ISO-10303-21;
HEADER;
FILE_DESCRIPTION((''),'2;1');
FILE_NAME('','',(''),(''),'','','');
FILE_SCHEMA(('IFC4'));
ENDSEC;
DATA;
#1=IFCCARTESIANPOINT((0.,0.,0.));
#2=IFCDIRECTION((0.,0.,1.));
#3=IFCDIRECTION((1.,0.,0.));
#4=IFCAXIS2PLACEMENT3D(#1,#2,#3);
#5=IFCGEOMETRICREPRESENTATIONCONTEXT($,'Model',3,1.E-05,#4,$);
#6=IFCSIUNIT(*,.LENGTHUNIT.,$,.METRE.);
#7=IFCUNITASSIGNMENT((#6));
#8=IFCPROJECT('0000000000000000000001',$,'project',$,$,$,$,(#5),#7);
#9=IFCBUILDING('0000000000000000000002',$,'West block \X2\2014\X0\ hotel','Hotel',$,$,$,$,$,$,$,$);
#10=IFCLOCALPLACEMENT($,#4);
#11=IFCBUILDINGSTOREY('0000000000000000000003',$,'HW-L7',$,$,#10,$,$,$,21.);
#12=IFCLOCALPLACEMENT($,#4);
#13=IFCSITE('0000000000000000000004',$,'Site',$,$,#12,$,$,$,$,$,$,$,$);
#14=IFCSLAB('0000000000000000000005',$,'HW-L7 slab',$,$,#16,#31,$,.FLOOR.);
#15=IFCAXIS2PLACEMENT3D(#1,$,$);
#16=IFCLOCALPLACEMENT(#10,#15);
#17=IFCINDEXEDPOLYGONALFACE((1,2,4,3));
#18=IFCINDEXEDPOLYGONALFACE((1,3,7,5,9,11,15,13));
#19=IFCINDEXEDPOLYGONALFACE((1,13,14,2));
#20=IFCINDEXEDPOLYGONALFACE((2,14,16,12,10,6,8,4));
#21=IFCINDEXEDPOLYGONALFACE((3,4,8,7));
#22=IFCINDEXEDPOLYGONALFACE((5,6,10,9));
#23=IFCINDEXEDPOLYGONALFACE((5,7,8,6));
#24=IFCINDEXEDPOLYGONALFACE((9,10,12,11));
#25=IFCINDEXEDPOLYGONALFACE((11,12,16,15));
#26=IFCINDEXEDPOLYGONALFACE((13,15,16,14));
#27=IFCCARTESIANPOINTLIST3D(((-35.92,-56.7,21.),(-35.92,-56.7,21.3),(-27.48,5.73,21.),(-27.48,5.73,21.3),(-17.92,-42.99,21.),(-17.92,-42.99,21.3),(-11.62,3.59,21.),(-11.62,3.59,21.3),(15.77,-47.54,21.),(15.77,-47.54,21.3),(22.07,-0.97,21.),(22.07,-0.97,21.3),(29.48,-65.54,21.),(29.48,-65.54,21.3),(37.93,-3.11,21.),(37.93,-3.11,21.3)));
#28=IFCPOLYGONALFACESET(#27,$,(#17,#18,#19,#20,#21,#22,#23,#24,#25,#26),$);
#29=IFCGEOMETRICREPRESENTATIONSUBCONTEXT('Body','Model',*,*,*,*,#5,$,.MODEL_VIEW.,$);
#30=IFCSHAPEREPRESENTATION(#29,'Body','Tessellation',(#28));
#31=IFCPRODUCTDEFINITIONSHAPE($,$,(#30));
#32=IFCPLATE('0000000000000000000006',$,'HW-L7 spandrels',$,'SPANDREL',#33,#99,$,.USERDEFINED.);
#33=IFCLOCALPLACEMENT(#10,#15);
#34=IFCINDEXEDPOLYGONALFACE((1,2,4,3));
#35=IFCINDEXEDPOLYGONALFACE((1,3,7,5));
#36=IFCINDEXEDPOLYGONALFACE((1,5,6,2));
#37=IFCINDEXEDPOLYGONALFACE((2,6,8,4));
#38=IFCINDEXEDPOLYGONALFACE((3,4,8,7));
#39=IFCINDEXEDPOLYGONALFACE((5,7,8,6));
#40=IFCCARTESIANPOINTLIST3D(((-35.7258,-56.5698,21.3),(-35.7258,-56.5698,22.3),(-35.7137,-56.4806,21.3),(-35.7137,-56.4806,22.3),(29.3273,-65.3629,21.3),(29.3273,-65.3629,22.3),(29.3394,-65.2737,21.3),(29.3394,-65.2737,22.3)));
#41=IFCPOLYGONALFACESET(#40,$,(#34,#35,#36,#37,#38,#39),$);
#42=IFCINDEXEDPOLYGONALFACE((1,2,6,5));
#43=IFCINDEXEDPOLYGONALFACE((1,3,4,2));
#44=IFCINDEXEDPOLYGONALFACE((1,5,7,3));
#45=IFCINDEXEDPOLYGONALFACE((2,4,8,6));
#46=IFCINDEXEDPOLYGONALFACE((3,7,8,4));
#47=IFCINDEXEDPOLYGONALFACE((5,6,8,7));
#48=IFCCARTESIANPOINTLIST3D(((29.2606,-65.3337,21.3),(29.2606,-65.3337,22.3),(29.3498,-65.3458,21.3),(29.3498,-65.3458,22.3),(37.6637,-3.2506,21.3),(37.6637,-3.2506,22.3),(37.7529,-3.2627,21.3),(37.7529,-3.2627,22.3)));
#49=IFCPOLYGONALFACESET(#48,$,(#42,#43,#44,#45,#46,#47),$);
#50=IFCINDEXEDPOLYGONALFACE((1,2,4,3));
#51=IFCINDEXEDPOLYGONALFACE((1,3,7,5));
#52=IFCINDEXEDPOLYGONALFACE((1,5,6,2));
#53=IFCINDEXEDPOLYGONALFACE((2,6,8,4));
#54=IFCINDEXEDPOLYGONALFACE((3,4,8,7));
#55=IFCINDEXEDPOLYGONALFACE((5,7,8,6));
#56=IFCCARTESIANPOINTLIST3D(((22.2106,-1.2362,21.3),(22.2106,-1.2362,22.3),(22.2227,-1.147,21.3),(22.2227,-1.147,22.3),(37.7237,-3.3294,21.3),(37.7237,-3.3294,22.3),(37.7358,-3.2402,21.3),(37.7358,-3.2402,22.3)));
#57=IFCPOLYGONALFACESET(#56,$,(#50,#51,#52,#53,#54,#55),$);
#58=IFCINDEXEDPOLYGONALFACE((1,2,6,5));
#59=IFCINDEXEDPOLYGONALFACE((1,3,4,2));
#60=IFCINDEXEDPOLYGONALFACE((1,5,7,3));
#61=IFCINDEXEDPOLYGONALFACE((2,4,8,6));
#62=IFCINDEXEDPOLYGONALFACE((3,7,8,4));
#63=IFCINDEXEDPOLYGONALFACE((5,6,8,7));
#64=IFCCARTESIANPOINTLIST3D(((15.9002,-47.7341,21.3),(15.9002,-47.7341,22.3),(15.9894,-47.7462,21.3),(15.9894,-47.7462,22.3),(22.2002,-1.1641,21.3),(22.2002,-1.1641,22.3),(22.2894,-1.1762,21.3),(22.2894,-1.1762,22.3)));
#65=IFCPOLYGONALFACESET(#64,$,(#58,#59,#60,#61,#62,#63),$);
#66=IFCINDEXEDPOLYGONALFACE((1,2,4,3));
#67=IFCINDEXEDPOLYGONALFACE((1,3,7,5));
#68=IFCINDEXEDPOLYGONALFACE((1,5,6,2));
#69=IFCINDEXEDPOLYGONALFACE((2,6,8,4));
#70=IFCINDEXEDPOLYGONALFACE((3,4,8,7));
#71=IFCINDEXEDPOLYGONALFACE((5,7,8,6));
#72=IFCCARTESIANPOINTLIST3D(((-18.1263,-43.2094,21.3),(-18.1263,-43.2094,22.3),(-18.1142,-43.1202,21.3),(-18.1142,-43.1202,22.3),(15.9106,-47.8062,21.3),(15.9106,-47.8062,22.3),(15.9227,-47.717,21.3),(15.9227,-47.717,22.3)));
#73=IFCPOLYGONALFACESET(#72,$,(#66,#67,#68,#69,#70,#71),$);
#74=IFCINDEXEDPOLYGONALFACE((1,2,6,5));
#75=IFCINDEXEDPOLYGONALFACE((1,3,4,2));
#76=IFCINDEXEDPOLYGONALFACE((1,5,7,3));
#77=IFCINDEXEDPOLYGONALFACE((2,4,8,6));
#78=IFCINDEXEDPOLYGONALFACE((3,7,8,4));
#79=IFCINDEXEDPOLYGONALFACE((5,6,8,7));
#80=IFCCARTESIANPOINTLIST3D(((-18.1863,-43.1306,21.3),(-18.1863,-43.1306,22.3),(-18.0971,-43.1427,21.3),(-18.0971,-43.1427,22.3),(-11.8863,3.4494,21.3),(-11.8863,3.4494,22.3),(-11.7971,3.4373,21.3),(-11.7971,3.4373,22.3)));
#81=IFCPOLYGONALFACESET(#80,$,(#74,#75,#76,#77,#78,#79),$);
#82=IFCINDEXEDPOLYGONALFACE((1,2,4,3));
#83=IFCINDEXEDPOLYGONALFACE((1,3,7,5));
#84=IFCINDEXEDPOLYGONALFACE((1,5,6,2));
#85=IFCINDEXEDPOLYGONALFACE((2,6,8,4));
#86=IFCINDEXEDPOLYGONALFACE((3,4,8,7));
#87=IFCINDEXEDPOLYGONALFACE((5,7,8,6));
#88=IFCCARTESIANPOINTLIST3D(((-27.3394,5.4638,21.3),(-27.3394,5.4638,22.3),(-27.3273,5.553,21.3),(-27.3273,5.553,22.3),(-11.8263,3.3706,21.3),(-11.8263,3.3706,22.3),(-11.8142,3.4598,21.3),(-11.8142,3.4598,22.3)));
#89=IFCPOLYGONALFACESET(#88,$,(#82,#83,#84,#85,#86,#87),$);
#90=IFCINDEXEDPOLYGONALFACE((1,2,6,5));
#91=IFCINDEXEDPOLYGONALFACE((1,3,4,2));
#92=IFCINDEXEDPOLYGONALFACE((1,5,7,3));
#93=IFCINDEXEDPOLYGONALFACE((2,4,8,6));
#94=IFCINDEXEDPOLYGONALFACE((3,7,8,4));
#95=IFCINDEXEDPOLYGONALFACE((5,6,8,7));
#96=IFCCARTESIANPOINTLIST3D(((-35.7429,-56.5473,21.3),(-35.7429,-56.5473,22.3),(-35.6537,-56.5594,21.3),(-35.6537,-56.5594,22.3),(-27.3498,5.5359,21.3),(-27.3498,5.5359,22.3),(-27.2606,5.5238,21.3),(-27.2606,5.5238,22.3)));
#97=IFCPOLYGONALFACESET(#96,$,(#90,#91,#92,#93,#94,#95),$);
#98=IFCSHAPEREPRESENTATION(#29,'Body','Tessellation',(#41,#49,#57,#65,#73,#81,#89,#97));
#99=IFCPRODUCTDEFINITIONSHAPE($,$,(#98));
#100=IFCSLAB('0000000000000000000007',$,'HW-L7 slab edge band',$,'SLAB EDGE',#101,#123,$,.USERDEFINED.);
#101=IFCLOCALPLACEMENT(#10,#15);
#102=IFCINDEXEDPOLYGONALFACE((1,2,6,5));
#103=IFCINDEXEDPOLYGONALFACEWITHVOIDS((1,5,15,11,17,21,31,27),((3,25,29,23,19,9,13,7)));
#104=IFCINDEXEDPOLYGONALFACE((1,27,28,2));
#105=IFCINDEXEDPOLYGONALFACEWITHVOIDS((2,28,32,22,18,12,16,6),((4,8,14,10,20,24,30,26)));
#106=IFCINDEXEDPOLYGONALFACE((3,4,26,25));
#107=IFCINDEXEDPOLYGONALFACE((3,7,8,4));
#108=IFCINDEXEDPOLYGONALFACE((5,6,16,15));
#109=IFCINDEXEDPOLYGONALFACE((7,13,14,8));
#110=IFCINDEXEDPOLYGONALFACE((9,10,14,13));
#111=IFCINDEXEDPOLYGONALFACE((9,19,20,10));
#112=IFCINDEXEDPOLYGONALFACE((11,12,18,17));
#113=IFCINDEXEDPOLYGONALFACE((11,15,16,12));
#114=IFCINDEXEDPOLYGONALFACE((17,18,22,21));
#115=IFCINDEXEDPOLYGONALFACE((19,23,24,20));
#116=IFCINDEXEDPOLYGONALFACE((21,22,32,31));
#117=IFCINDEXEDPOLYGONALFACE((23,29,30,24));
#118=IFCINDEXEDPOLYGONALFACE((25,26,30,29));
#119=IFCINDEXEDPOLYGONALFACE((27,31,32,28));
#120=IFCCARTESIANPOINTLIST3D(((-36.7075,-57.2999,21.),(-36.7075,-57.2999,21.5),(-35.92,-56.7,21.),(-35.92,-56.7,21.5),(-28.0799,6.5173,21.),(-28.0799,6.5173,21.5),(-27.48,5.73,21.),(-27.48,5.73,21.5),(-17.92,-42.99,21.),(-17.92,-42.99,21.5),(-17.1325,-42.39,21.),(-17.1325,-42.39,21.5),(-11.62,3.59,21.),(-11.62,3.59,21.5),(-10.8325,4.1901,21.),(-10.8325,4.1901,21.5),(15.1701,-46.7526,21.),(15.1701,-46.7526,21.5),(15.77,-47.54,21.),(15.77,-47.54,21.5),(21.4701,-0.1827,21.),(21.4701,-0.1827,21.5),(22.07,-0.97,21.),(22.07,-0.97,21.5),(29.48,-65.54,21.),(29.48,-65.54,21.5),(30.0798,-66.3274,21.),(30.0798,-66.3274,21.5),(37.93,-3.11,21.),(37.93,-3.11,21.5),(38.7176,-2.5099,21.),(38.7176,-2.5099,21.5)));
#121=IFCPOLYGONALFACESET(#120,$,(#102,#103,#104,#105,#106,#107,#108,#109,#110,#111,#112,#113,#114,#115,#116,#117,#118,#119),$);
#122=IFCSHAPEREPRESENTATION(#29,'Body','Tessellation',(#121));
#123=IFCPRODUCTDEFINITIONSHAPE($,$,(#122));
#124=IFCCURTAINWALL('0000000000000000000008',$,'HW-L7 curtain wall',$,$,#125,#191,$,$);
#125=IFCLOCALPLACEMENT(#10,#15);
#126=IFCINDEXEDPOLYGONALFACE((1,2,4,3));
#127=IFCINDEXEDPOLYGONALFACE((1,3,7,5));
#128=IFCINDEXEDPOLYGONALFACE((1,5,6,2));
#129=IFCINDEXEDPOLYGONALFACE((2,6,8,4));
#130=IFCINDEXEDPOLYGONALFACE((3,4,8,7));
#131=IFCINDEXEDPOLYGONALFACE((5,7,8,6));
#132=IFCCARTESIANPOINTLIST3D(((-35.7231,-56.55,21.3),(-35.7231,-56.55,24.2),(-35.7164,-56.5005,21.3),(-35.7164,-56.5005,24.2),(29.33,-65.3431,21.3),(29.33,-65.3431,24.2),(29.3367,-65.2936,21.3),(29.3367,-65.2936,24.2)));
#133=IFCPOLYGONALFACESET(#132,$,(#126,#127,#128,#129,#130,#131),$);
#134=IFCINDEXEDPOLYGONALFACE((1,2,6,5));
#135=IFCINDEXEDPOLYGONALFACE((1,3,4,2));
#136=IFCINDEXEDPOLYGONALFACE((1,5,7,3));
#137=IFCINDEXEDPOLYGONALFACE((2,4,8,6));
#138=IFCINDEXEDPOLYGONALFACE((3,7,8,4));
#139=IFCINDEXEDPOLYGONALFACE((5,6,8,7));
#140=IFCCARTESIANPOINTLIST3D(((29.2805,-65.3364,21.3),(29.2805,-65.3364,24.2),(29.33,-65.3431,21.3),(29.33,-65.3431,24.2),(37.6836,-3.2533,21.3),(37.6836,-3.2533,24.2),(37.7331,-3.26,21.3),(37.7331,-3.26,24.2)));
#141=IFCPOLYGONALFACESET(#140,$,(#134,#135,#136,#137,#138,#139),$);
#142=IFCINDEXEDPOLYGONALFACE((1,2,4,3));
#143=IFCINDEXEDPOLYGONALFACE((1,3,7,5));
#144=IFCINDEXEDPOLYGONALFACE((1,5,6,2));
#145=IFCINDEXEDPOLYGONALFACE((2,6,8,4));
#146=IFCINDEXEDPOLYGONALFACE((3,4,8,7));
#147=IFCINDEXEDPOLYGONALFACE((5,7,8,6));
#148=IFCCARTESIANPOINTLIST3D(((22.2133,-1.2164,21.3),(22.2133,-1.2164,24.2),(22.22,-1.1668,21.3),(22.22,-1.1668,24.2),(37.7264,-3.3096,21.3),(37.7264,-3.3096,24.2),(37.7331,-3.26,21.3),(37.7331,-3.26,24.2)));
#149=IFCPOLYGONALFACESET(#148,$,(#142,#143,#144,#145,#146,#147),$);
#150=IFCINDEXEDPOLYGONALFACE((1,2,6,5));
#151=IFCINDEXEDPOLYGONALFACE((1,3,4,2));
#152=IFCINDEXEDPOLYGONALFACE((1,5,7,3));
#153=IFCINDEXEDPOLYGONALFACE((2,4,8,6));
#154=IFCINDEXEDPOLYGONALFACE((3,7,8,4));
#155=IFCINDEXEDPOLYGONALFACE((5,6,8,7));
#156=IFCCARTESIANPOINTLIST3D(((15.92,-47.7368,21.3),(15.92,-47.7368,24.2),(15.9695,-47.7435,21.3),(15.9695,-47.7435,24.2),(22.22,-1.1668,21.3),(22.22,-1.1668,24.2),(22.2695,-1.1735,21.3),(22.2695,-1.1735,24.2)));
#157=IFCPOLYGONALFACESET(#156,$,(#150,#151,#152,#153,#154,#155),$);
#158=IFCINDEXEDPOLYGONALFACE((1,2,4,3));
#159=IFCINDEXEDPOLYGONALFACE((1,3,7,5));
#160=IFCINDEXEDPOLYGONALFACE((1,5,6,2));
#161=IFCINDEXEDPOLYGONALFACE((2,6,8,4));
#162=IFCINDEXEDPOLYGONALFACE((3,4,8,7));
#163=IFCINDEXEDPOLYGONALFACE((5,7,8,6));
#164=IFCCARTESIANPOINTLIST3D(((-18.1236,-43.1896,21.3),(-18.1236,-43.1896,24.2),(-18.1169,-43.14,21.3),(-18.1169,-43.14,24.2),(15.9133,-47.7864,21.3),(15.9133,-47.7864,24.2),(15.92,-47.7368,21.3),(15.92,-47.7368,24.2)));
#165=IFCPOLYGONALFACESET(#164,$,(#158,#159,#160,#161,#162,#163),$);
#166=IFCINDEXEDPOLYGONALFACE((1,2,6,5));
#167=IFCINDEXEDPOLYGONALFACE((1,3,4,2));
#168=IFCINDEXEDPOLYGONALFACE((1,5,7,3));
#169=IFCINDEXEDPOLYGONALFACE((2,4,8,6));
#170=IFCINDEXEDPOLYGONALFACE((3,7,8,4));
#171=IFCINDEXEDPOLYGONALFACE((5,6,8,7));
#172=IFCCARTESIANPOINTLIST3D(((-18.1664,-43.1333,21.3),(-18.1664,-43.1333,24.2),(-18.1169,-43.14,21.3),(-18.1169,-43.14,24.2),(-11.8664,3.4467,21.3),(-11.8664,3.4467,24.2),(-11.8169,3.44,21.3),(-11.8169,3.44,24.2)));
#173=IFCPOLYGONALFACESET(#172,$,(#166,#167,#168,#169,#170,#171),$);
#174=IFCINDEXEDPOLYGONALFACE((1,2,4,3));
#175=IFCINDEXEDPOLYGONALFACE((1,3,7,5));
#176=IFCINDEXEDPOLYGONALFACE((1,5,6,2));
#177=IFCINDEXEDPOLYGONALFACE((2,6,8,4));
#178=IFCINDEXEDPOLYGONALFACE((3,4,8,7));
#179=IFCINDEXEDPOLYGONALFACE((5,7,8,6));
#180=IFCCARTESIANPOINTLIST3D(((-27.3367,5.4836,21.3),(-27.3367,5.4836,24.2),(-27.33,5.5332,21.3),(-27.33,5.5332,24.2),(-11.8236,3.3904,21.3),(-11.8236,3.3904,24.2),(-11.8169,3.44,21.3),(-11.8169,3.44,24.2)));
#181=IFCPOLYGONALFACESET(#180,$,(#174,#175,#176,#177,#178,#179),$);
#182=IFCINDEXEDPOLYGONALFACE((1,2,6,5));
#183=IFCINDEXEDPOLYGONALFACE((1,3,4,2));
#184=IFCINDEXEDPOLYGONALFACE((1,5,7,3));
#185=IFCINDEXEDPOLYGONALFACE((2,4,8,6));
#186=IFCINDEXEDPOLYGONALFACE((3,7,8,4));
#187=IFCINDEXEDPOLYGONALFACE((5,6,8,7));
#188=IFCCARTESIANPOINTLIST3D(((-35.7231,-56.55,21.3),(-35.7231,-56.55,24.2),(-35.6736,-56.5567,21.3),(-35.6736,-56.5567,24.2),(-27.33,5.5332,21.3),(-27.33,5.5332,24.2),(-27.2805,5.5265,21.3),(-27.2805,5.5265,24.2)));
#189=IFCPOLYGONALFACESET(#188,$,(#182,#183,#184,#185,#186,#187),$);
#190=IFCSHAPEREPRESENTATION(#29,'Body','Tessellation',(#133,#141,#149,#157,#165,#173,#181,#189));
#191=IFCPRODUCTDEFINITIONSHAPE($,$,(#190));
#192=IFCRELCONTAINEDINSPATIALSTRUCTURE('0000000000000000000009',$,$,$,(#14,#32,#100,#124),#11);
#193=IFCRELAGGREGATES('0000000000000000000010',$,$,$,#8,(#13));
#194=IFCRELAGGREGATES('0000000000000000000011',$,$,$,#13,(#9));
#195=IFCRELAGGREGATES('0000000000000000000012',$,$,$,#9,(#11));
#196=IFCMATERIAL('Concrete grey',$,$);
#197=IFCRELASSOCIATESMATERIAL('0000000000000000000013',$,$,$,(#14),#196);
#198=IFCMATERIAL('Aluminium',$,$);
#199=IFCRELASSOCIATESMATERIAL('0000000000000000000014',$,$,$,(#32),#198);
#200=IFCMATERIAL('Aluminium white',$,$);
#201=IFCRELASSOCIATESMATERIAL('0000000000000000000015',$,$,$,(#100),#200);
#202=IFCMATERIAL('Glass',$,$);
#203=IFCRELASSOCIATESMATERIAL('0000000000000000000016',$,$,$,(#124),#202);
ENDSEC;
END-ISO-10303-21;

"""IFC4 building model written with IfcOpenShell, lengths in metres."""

from ifc_helpers import new_model, si_unit, frame, origin_with_axes, place, context, subcontext, project, spatial, polyline, outline, extrude, material, element, save


model = new_model("IFC4")

# Units and contexts
model_context = context("Model", 3, precision=1e-05, world=origin_with_axes())
body_context = subcontext(model_context, "Body", "Model", "MODEL_VIEW")
ifc_project = project(units=[si_unit("LENGTHUNIT", "METRE")], contexts=[model_context])

# Site, building, storey
site_placement = place(None, origin_with_axes())
site = spatial("IfcSite", under=ifc_project, at=site_placement, Name="Site")
building = spatial("IfcBuilding", under=site, Name="West block — hotel", Description="Hotel")
storey_placement = place(None, origin_with_axes())
storey = spatial("IfcBuildingStorey", under=building, at=storey_placement, Name="HW-L7", Elevation=21.0)

# Shared definitions
ifc_material_1 = material(Name="Aluminium")

# Slab
ifc_material_2 = material(Name="Concrete grey")
slab_1_placement = place(storey_placement, origin_with_axes())
element("IfcSlab", 1, at=slab_1_placement, inside=storey, material=ifc_material_2, Name="HW-L7 slab", PredefinedType="FLOOR", context=body_context, shape_type="SweptSolid", body=[
    extrude(outline(polyline([(-35.92, -56.7), (29.48, -65.54), (37.93, -3.11), (22.07, -0.97), (15.77, -47.54), (-17.92, -42.99), (-11.62, 3.59), (-27.48, 5.73), (-35.92, -56.7)])), frame((0.0, 0.0, 21.0), z_axis=(0.0, 0.0, 1.0), x_axis=(1.0, 0.0, 0.0)), (0.0, 0.0, 1.0), 0.3),
])

# Plate
plate_placement = place(storey_placement, origin_with_axes())
element("IfcPlate", 2, at=plate_placement, inside=storey, material=ifc_material_1, Name="HW-L7 spandrels", ObjectType="SPANDREL", PredefinedType="USERDEFINED", context=body_context, shape_type="SweptSolid", body=[
    extrude(outline(polyline([(-35.7258, -56.5698), (29.3273, -65.3629), (29.3394, -65.2737), (-35.7137, -56.4806), (-35.7258, -56.5698)])), frame((0.0, 0.0, 21.3), z_axis=(0.0, 0.0, 1.0), x_axis=(1.0, 0.0, 0.0)), (0.0, 0.0, 1.0), 1.0),
    extrude(outline(polyline([(29.3498, -65.3458), (37.7529, -3.2627), (37.6637, -3.2506), (29.2606, -65.3337), (29.3498, -65.3458)])), frame((0.0, 0.0, 21.3), z_axis=(0.0, 0.0, 1.0), x_axis=(1.0, 0.0, 0.0)), (0.0, 0.0, 1.0), 1.0),
    extrude(outline(polyline([(37.7358, -3.2402), (22.2227, -1.147), (22.2106, -1.2362), (37.7237, -3.3294), (37.7358, -3.2402)])), frame((0.0, 0.0, 21.3), z_axis=(0.0, 0.0, 1.0), x_axis=(1.0, 0.0, 0.0)), (0.0, 0.0, 1.0), 1.0),
    extrude(outline(polyline([(22.2002, -1.1641), (15.9002, -47.7341), (15.9894, -47.7462), (22.2894, -1.1762), (22.2002, -1.1641)])), frame((0.0, 0.0, 21.3), z_axis=(0.0, 0.0, 1.0), x_axis=(1.0, 0.0, 0.0)), (0.0, 0.0, 1.0), 1.0),
    extrude(outline(polyline([(15.9227, -47.717), (-18.1142, -43.1202), (-18.1263, -43.2094), (15.9106, -47.8062), (15.9227, -47.717)])), frame((0.0, 0.0, 21.3), z_axis=(0.0, 0.0, 1.0), x_axis=(1.0, 0.0, 0.0)), (0.0, 0.0, 1.0), 1.0),
    extrude(outline(polyline([(-18.0971, -43.1427), (-11.7971, 3.4373), (-11.8863, 3.4494), (-18.1863, -43.1306), (-18.0971, -43.1427)])), frame((0.0, 0.0, 21.3), z_axis=(0.0, 0.0, 1.0), x_axis=(1.0, 0.0, 0.0)), (0.0, 0.0, 1.0), 1.0),
    extrude(outline(polyline([(-11.8142, 3.4598), (-27.3273, 5.553), (-27.3394, 5.4638), (-11.8263, 3.3706), (-11.8142, 3.4598)])), frame((0.0, 0.0, 21.3), z_axis=(0.0, 0.0, 1.0), x_axis=(1.0, 0.0, 0.0)), (0.0, 0.0, 1.0), 1.0),
    extrude(outline(polyline([(-27.3498, 5.5359), (-35.7429, -56.5473), (-35.6537, -56.5594), (-27.2606, 5.5238), (-27.3498, 5.5359)])), frame((0.0, 0.0, 21.3), z_axis=(0.0, 0.0, 1.0), x_axis=(1.0, 0.0, 0.0)), (0.0, 0.0, 1.0), 1.0),
])

# Slab
ifc_material_3 = material(Name="Aluminium white")
slab_2_placement = place(storey_placement, origin_with_axes())
element("IfcSlab", 3, at=slab_2_placement, inside=storey, material=ifc_material_3, Name="HW-L7 slab edge band", ObjectType="SLAB EDGE", PredefinedType="USERDEFINED", context=body_context, shape_type="SweptSolid", body=[
    extrude(outline(polyline([(-36.7075, -57.2999), (30.0798, -66.3274), (38.7176, -2.5099), (21.4701, -0.1827), (15.1701, -46.7526), (-17.1325, -42.39), (-10.8325, 4.1901), (-28.0799, 6.5173), (-36.7075, -57.2999)]), holes=[polyline([(-35.92, -56.7), (29.48, -65.54), (37.93, -3.11), (22.07, -0.97), (15.77, -47.54), (-17.92, -42.99), (-11.62, 3.59), (-27.48, 5.73), (-35.92, -56.7)])]), frame((0.0, 0.0, 21.0), z_axis=(0.0, 0.0, 1.0), x_axis=(1.0, 0.0, 0.0)), (0.0, 0.0, 1.0), 0.5),
])

# Curtain wall
ifc_material_4 = material(Name="Glass")
curtain_wall_placement = place(storey_placement, origin_with_axes())
element("IfcCurtainWall", 4, at=curtain_wall_placement, inside=storey, material=ifc_material_4, Name="HW-L7 curtain wall", context=body_context, shape_type="SweptSolid", body=[
    extrude(outline(polyline([(-35.7231, -56.55), (29.33, -65.3431), (29.3367, -65.2936), (-35.7164, -56.5005), (-35.7231, -56.55)])), frame((0.0, 0.0, 21.3), z_axis=(0.0, 0.0, 1.0), x_axis=(1.0, 0.0, 0.0)), (0.0, 0.0, 1.0), 2.9),
    extrude(outline(polyline([(29.33, -65.3431), (37.7331, -3.26), (37.6836, -3.2533), (29.2805, -65.3364), (29.33, -65.3431)])), frame((0.0, 0.0, 21.3), z_axis=(0.0, 0.0, 1.0), x_axis=(1.0, 0.0, 0.0)), (0.0, 0.0, 1.0), 2.9),
    extrude(outline(polyline([(37.7331, -3.26), (22.22, -1.1668), (22.2133, -1.2164), (37.7264, -3.3096), (37.7331, -3.26)])), frame((0.0, 0.0, 21.3), z_axis=(0.0, 0.0, 1.0), x_axis=(1.0, 0.0, 0.0)), (0.0, 0.0, 1.0), 2.9),
    extrude(outline(polyline([(22.22, -1.1668), (15.92, -47.7368), (15.9695, -47.7435), (22.2695, -1.1735), (22.22, -1.1668)])), frame((0.0, 0.0, 21.3), z_axis=(0.0, 0.0, 1.0), x_axis=(1.0, 0.0, 0.0)), (0.0, 0.0, 1.0), 2.9),
    extrude(outline(polyline([(15.92, -47.7368), (-18.1169, -43.14), (-18.1236, -43.1896), (15.9133, -47.7864), (15.92, -47.7368)])), frame((0.0, 0.0, 21.3), z_axis=(0.0, 0.0, 1.0), x_axis=(1.0, 0.0, 0.0)), (0.0, 0.0, 1.0), 2.9),
    extrude(outline(polyline([(-18.1169, -43.14), (-11.8169, 3.44), (-11.8664, 3.4467), (-18.1664, -43.1333), (-18.1169, -43.14)])), frame((0.0, 0.0, 21.3), z_axis=(0.0, 0.0, 1.0), x_axis=(1.0, 0.0, 0.0)), (0.0, 0.0, 1.0), 2.9),
    extrude(outline(polyline([(-11.8169, 3.44), (-27.33, 5.5332), (-27.3367, 5.4836), (-11.8236, 3.3904), (-11.8169, 3.44)])), frame((0.0, 0.0, 21.3), z_axis=(0.0, 0.0, 1.0), x_axis=(1.0, 0.0, 0.0)), (0.0, 0.0, 1.0), 2.9),
    extrude(outline(polyline([(-27.33, 5.5332), (-35.7231, -56.55), (-35.6736, -56.5567), (-27.2805, 5.5265), (-27.33, 5.5332)])), frame((0.0, 0.0, 21.3), z_axis=(0.0, 0.0, 1.0), x_axis=(1.0, 0.0, 0.0)), (0.0, 0.0, 1.0), 2.9),
])

save(model, "model.ifc")
